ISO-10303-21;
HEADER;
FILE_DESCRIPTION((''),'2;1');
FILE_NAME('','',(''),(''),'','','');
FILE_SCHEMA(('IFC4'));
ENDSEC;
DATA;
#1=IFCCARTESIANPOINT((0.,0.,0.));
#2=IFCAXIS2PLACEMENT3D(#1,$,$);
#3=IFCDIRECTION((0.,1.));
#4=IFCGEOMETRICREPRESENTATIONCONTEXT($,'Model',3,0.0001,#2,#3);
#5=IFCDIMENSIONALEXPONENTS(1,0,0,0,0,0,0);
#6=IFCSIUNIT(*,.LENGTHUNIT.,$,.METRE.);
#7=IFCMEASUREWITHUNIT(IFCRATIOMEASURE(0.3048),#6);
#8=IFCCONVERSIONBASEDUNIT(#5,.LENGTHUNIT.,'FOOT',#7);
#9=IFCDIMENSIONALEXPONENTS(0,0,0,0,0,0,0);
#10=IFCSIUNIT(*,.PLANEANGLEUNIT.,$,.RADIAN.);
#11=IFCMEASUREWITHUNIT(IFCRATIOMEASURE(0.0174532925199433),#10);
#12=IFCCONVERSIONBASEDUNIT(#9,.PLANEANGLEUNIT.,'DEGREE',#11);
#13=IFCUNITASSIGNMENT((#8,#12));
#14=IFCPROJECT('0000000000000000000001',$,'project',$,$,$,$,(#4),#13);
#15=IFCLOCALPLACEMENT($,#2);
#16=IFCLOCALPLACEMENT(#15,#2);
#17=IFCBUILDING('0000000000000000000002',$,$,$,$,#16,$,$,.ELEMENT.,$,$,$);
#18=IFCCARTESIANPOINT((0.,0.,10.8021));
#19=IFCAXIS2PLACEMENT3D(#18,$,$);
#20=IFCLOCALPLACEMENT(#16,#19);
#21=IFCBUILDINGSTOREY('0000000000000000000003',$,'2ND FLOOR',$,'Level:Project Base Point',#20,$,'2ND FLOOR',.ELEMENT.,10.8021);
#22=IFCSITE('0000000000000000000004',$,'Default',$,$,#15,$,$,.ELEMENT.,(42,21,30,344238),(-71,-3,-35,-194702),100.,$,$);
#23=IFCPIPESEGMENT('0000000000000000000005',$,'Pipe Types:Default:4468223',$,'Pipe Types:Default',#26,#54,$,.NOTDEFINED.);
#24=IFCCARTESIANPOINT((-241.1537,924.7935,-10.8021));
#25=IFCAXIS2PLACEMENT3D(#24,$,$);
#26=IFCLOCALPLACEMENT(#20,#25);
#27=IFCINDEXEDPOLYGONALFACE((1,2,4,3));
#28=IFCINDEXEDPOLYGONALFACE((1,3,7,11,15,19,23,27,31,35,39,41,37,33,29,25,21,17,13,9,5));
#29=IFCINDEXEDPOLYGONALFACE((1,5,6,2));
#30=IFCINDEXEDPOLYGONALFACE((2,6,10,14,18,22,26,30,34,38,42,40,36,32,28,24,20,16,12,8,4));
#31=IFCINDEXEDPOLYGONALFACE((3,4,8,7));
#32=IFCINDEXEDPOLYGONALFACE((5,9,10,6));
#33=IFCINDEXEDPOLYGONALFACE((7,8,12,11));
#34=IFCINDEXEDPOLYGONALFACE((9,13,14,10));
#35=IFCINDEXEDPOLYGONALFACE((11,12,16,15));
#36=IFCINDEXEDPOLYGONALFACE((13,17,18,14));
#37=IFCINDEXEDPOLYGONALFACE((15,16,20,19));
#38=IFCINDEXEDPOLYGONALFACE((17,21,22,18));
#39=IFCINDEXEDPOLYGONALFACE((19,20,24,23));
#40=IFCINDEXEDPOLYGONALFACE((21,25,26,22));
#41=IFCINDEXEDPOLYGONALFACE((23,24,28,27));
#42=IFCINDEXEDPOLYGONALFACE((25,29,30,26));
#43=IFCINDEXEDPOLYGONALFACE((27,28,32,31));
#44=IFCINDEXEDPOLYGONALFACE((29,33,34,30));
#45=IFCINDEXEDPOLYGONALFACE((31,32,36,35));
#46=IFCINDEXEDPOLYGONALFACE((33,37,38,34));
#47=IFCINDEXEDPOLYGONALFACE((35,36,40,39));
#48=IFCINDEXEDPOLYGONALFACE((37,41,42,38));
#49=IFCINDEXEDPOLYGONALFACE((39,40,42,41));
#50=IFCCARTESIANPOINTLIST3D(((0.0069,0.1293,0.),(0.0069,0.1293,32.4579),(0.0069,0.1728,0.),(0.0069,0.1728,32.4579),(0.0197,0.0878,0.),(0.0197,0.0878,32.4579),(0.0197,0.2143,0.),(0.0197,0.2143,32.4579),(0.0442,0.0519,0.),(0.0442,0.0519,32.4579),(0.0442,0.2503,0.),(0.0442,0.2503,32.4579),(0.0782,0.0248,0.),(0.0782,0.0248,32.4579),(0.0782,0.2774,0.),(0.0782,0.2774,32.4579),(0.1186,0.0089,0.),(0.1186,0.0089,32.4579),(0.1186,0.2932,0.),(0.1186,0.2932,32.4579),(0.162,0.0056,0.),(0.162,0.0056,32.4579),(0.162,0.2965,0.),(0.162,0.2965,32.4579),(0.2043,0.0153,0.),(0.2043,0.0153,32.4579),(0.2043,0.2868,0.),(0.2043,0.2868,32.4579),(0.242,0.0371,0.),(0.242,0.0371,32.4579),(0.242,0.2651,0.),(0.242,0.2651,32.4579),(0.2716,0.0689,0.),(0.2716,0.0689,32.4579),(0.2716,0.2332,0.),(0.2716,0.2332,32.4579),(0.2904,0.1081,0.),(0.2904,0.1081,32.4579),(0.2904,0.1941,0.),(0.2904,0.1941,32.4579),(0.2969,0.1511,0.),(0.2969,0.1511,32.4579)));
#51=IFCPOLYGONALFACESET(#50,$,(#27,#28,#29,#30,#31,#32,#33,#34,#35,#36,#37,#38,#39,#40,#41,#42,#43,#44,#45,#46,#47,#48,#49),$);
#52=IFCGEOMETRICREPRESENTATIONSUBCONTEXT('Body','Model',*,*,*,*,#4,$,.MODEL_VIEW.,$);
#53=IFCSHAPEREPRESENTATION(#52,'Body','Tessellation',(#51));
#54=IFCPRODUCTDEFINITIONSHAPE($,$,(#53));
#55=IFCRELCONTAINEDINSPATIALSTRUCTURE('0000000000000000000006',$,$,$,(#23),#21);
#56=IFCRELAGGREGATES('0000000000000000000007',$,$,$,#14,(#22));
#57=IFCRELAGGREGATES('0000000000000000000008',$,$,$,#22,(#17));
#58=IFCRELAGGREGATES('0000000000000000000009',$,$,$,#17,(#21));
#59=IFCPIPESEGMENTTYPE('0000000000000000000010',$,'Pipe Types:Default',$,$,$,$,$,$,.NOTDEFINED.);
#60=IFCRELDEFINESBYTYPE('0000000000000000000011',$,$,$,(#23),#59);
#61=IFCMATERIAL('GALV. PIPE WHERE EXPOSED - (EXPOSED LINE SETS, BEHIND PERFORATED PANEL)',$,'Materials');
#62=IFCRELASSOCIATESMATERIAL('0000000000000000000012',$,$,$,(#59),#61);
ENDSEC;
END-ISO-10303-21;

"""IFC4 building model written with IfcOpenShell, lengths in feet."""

from ifc_helpers import new_model, entity, si_unit, converted_unit, direction, frame, origin, origin_2d_with_axis, place, context, subcontext, project, spatial, circle, extrude, material, type_object, element, save


model = new_model("IFC4")

# Units and contexts
model_context = context("Model", 3, precision=0.0001, world=origin(), true_north=direction((0.0, 1.0)))
body_context = subcontext(model_context, "Body", "Model", "MODEL_VIEW")
ifc_project = project(units=[converted_unit("LENGTHUNIT", "FOOT", entity("IfcRatioMeasure", 0.3048), si_unit("LENGTHUNIT", "METRE"), dimensions=[1, 0, 0, 0, 0, 0, 0]), converted_unit("PLANEANGLEUNIT", "DEGREE", entity("IfcRatioMeasure", 0.0174532925199433), si_unit("PLANEANGLEUNIT", "RADIAN"), dimensions=[0, 0, 0, 0, 0, 0, 0])], contexts=[model_context])

# Site, building, storey
site_placement = place(None, origin())
site = spatial("IfcSite", under=ifc_project, at=site_placement, Name="Default", CompositionType="ELEMENT", RefLatitude=(42, 21, 30, 344238), RefLongitude=(-71, -3, -35, -194702), RefElevation=100.0)
building_placement = place(site_placement, origin())
building = spatial("IfcBuilding", under=site, at=building_placement, CompositionType="ELEMENT")
storey_placement = place(building_placement, frame((0.0, 0.0, 10.8021)))
storey = spatial("IfcBuildingStorey", under=building, at=storey_placement, Name="2ND FLOOR", ObjectType="Level:Project Base Point", LongName="2ND FLOOR", CompositionType="ELEMENT", Elevation=10.8021)

# Pipe segment
ifc_material_1 = material(Name="GALV. PIPE WHERE EXPOSED - (EXPOSED LINE SETS, BEHIND PERFORATED PANEL)", Category="Materials")
pipe_segment_type = type_object("IfcPipeSegmentType", Name="Pipe Types:Default", PredefinedType="NOTDEFINED", material=ifc_material_1)
for number, where, name in (
    (1, (-241.1537, 924.7935, -10.8021), "Pipe Types:Default:4468223"),
):
    element("IfcPipeSegment", number, at=place(storey_placement, frame(where)), inside=storey, type_object=pipe_segment_type, Name=name, ObjectType="Pipe Types:Default", PredefinedType="NOTDEFINED", context=body_context, shape_type="SweptSolid", body=[
        extrude(circle(Radius=0.1458, at=origin_2d_with_axis()), frame((0.1511, 0.1511, 0.0)), (0.0, 0.0, 1.0), 32.4579),
    ])

save(model, "model.ifc")
